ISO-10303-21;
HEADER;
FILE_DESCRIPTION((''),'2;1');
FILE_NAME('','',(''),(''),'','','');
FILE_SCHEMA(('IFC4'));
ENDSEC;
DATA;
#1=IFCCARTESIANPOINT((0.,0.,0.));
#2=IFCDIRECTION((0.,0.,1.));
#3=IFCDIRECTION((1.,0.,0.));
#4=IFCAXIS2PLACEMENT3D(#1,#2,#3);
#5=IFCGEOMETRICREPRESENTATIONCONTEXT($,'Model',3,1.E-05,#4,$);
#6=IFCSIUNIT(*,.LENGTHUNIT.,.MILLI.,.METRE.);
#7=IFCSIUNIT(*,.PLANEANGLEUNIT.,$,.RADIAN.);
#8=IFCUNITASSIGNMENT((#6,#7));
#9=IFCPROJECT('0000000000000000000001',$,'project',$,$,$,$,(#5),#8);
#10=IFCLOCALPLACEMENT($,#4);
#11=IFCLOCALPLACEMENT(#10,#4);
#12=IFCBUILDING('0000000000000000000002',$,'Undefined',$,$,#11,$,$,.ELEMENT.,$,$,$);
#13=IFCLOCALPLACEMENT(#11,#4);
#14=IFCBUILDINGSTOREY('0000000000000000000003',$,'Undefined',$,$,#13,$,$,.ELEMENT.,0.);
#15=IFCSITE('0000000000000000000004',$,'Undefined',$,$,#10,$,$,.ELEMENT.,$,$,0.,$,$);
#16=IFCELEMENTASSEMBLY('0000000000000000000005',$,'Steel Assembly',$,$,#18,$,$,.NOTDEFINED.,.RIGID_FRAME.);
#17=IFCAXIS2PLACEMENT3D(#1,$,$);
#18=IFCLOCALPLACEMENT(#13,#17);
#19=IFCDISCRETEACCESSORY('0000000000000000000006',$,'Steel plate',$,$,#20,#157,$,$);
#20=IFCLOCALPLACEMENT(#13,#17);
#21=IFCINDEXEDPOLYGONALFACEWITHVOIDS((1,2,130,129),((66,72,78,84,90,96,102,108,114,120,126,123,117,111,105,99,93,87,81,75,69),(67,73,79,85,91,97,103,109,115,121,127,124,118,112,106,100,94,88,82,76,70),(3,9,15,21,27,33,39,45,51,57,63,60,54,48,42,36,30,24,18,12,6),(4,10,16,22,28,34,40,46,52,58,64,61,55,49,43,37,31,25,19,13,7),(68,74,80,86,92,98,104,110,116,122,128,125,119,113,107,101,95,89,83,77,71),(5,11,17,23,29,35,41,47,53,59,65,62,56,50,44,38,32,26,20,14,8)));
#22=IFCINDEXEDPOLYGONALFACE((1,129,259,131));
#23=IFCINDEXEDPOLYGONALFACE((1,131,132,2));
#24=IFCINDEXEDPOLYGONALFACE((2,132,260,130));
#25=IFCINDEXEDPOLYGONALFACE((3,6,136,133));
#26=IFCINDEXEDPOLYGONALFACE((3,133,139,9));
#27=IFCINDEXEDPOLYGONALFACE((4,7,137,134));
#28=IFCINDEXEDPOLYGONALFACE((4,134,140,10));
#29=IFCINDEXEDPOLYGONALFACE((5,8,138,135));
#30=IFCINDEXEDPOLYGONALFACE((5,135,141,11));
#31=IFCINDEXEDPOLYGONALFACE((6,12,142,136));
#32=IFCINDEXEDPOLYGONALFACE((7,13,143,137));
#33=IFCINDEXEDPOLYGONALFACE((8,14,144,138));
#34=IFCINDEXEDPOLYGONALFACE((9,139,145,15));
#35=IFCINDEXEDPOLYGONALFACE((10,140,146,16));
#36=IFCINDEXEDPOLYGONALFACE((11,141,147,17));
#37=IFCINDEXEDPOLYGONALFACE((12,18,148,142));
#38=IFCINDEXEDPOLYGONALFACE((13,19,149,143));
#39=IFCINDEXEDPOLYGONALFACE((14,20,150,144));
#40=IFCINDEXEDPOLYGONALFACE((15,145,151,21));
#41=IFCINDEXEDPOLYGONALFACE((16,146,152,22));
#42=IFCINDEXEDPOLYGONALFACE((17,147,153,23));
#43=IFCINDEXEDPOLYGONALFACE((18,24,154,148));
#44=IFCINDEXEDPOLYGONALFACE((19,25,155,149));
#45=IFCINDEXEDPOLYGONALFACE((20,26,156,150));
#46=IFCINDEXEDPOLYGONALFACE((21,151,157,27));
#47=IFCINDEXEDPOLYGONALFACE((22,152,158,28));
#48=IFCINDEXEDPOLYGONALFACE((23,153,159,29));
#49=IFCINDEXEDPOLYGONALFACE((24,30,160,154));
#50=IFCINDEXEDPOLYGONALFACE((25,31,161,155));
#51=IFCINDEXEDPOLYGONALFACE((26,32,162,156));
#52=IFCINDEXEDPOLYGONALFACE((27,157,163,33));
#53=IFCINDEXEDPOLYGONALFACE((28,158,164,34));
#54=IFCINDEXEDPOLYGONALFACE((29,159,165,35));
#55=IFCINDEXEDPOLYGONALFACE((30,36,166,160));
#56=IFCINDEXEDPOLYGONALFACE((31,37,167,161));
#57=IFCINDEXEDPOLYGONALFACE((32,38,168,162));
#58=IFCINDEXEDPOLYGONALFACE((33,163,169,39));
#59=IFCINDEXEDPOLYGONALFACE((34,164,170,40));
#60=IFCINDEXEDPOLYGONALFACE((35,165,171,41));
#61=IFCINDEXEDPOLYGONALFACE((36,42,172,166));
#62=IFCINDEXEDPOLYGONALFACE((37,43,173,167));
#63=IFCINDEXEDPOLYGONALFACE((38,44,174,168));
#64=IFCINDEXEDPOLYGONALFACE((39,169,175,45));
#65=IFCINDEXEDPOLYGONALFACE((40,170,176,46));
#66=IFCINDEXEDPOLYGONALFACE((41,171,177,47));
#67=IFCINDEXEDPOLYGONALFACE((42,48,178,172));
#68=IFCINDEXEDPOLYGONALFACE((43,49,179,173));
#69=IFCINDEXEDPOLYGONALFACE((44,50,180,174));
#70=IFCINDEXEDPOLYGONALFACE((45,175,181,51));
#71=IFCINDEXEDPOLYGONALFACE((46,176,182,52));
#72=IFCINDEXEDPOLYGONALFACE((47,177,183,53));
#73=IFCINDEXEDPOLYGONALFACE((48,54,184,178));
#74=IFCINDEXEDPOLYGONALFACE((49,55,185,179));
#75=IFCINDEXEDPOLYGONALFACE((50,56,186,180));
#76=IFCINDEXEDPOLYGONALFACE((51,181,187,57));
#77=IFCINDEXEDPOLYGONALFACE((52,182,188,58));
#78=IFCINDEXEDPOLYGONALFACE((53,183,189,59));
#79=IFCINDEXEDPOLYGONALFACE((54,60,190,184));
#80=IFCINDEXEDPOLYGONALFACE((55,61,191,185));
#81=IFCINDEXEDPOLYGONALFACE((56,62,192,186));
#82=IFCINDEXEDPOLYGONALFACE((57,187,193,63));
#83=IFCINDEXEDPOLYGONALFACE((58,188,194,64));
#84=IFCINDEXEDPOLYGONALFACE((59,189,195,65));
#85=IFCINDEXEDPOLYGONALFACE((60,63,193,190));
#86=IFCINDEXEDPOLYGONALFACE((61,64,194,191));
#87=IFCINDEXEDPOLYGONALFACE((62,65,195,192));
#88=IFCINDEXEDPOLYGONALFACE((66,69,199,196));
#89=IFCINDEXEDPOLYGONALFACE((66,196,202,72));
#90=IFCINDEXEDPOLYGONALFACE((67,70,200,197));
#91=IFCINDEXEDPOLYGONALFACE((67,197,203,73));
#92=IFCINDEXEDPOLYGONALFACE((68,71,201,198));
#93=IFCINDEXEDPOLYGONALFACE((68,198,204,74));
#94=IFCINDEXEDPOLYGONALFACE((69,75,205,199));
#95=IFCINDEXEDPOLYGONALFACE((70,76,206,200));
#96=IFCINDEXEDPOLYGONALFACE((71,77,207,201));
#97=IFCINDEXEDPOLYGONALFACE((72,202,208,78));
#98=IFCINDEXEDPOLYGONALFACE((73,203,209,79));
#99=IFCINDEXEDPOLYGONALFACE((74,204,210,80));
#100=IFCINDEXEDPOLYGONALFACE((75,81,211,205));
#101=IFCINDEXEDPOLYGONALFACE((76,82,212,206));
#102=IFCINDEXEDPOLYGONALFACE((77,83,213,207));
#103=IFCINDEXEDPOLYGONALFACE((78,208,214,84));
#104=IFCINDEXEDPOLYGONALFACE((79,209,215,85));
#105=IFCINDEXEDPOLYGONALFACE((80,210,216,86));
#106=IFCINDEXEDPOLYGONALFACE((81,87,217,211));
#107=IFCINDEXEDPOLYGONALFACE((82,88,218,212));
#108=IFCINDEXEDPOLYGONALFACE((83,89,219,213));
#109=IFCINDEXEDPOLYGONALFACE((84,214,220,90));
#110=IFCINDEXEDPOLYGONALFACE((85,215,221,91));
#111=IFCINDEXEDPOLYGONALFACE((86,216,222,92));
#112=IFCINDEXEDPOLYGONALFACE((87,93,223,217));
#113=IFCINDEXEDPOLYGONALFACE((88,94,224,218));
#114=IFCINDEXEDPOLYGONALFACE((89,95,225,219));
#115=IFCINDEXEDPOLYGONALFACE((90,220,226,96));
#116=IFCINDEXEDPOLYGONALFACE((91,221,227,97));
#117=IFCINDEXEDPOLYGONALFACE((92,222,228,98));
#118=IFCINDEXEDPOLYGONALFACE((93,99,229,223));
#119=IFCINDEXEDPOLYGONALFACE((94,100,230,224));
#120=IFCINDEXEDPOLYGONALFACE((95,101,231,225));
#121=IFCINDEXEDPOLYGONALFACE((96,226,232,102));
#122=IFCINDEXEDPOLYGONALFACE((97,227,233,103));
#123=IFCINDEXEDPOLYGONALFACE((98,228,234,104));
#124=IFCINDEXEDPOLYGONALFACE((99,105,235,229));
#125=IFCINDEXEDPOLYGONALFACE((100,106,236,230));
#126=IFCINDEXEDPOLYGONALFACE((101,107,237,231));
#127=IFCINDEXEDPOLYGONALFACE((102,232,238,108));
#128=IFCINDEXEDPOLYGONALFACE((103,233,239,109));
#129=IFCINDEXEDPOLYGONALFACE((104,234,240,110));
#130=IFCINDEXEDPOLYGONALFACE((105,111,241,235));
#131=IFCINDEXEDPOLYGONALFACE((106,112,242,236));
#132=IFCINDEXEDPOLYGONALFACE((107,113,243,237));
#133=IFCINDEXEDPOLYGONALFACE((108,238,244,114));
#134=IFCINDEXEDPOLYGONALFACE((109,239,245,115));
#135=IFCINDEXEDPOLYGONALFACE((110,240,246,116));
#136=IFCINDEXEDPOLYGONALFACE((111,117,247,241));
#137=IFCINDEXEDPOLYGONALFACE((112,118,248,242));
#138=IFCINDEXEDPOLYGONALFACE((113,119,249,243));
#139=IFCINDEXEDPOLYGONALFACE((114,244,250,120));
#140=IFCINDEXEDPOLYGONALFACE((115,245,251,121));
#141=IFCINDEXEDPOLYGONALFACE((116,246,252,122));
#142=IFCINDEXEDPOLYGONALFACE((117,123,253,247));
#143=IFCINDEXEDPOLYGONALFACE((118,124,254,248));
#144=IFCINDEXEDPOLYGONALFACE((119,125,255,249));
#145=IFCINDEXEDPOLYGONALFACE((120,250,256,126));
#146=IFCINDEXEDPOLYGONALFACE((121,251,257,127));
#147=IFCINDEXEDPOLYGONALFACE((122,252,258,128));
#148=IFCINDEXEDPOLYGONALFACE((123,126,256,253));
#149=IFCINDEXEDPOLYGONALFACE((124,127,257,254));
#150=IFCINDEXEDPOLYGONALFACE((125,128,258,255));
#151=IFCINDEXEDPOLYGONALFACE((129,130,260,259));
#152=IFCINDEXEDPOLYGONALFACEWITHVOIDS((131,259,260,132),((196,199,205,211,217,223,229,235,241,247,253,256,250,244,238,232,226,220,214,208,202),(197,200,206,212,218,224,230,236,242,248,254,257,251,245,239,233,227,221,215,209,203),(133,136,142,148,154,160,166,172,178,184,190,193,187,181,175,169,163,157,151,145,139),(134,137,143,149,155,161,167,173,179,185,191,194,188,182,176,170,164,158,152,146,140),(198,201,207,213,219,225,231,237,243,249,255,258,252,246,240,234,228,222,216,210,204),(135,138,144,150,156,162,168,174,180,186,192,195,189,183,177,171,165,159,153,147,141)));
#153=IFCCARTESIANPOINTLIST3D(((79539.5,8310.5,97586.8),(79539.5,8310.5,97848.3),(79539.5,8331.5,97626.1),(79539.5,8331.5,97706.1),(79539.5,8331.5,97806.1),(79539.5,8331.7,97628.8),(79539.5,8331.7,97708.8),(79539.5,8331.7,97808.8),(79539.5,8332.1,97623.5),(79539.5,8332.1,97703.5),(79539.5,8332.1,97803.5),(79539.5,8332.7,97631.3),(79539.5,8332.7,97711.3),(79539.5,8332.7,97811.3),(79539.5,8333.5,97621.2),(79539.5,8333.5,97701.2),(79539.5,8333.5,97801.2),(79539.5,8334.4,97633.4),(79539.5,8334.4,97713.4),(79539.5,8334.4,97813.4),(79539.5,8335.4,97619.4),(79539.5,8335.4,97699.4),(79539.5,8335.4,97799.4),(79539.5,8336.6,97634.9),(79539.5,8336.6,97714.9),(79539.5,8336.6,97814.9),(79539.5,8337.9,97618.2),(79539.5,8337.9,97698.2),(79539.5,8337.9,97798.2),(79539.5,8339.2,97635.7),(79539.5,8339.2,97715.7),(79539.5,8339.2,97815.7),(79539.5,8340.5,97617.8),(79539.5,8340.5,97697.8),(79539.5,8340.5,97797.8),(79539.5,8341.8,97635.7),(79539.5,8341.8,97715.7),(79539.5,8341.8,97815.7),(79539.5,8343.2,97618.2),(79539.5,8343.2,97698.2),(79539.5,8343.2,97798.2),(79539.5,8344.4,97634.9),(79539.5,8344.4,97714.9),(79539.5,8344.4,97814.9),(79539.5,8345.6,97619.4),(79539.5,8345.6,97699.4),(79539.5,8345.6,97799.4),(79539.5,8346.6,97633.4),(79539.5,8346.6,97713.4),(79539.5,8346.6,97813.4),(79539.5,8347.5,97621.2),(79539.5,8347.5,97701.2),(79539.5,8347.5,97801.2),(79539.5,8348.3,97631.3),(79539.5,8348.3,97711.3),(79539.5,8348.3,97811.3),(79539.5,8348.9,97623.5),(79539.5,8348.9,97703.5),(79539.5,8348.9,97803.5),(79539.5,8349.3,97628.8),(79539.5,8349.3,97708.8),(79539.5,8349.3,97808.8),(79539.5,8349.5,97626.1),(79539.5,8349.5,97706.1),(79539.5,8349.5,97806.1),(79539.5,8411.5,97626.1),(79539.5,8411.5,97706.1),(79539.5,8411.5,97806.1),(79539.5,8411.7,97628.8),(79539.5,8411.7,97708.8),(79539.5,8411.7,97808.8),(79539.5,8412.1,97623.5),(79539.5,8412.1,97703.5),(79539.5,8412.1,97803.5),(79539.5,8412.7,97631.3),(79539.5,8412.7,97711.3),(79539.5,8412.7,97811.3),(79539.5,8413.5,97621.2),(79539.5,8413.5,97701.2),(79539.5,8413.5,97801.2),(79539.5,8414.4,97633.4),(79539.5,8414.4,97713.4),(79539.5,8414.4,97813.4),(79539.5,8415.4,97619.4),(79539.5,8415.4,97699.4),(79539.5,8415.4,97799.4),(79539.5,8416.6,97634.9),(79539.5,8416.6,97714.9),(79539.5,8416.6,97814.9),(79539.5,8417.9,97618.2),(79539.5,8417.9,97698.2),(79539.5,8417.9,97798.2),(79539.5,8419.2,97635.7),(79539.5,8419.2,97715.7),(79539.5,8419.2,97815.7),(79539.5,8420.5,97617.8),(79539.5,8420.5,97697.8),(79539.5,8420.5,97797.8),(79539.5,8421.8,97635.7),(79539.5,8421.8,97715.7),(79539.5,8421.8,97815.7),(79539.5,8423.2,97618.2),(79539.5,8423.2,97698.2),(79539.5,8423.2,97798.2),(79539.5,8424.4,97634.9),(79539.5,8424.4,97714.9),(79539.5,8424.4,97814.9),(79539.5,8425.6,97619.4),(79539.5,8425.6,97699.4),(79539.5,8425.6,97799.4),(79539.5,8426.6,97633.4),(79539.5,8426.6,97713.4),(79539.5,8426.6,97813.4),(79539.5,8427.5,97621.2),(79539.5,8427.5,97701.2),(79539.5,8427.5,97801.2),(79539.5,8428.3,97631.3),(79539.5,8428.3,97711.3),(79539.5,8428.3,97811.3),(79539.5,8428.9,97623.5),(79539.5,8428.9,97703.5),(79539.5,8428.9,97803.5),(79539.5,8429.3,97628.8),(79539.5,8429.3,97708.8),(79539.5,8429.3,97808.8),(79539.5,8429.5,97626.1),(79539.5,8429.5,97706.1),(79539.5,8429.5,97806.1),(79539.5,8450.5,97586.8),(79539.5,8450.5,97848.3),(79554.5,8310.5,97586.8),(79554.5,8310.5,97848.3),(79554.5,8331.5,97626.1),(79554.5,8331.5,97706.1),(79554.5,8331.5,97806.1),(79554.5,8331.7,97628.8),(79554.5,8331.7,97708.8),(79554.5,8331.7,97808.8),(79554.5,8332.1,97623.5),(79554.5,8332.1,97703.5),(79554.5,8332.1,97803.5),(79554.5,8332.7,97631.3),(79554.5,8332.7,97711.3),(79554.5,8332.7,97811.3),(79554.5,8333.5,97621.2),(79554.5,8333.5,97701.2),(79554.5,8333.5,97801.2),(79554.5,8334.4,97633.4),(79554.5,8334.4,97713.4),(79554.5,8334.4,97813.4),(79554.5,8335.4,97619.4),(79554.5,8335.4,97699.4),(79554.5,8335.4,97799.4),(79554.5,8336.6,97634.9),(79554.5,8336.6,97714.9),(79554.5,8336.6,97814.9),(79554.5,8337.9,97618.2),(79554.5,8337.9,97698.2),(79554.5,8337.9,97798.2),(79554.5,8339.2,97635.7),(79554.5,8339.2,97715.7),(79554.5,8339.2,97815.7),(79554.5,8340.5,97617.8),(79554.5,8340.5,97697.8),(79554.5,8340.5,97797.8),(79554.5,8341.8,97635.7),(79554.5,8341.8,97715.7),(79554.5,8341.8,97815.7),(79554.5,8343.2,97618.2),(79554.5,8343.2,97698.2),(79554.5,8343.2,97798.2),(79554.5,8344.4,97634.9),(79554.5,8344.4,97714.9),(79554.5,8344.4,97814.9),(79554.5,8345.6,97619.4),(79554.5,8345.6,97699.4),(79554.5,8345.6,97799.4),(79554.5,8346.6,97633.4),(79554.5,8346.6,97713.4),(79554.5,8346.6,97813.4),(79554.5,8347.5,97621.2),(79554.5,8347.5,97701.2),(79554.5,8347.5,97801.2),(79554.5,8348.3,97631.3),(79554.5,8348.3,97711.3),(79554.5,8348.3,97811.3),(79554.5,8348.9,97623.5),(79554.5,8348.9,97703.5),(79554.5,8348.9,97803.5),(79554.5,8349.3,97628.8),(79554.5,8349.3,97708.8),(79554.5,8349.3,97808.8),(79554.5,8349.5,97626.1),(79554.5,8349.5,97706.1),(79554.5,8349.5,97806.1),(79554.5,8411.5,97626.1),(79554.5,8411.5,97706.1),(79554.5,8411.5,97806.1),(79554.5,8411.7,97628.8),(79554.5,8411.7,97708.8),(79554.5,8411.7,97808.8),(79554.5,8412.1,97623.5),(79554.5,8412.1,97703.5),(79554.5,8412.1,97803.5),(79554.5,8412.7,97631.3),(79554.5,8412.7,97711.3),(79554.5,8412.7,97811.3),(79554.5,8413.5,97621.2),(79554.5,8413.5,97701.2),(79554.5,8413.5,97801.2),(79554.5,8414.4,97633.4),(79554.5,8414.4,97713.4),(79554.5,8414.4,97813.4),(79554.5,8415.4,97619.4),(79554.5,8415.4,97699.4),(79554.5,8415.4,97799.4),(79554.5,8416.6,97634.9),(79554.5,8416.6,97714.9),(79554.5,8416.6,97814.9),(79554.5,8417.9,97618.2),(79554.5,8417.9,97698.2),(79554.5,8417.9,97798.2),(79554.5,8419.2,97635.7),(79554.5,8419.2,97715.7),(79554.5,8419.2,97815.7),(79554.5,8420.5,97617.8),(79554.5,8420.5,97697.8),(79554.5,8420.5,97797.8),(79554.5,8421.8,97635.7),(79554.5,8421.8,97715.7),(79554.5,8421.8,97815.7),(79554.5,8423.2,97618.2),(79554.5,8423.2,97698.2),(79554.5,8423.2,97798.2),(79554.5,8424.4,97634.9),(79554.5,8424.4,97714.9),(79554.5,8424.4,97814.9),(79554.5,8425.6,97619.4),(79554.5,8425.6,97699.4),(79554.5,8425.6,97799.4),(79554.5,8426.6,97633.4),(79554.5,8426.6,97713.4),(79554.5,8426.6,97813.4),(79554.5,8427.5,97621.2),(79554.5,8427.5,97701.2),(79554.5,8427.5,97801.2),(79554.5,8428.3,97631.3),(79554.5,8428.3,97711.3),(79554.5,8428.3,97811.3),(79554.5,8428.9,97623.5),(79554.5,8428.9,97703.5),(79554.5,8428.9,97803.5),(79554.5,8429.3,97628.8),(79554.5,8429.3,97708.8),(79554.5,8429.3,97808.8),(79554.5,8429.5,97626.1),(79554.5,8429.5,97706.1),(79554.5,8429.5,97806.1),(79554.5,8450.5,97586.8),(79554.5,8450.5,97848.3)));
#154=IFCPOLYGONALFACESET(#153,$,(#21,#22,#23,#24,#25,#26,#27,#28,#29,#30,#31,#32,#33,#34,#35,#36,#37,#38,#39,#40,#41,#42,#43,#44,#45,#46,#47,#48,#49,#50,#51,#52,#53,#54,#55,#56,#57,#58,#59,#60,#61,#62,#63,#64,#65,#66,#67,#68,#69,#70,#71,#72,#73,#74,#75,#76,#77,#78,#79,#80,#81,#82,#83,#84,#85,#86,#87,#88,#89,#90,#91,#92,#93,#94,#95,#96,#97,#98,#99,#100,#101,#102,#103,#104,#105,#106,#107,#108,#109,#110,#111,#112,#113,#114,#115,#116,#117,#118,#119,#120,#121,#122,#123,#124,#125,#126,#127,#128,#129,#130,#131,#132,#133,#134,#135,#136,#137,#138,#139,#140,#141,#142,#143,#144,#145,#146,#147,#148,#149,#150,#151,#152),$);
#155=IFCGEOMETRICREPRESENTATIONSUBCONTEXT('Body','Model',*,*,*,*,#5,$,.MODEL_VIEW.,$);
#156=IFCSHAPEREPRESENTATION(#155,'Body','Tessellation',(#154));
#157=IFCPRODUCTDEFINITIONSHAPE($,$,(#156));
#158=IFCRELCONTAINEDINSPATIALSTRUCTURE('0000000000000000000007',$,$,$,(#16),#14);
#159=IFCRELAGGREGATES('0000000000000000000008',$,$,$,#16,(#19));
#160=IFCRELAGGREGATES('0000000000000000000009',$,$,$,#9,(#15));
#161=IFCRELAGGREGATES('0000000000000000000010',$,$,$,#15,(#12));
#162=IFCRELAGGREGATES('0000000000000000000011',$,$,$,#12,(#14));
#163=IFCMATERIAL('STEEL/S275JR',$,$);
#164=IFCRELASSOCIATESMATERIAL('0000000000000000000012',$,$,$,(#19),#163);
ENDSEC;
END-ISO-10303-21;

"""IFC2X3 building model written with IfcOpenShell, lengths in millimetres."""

from ifc_helpers import new_model, si_unit, frame, origin_with_axes, origin_2d_with_axis, place, context, subcontext, project, spatial, polyline, circle, outline, extrude, source, transform, mapped, material, element, aggregate, save


model = new_model("IFC2X3")

# Units and contexts
model_context = context("Model", 3, precision=1e-05, world=origin_with_axes())
body_context = subcontext(model_context, "Body", "Model", "MODEL_VIEW")
ifc_project = project(units=[si_unit("LENGTHUNIT", "METRE", prefix="MILLI"), si_unit("PLANEANGLEUNIT", "RADIAN")], contexts=[model_context])

# Site, building, storey
site_placement = place(None, origin_with_axes())
site = spatial("IfcSite", under=ifc_project, at=site_placement, Name="Undefined", CompositionType="ELEMENT", RefElevation=0.0)
building_placement = place(site_placement, origin_with_axes())
building = spatial("IfcBuilding", under=site, at=building_placement, Name="Undefined", CompositionType="ELEMENT")
storey_placement = place(building_placement, origin_with_axes())
storey = spatial("IfcBuildingStorey", under=building, at=storey_placement, Name="Undefined", CompositionType="ELEMENT", Elevation=0.0)

# Shared definitions
ifc_material_1 = material(Name="STEEL/S275JR")

# Element assembly
assembly_1_placement = place(storey_placement, origin_with_axes())
assembly_1 = element("IfcElementAssembly", 1, at=assembly_1_placement, inside=storey, Name="Steel Assembly", AssemblyPlace="NOTDEFINED", PredefinedType="RIGID_FRAME")

# Shared definitions
shared_shape_1 = source(origin_with_axes(), body_context, "Body", "SweptSolid", [
    extrude(circle(Radius=9.0, at=origin_2d_with_axis()), frame((0.0, -20.1, 0.0), z_axis=(0.0, 1.0, 0.0), x_axis=(1.0, 0.0, 0.0)), (0.0, 0.0, 1.0), 35.3),
])

# Discrete accessory, opening
discrete_accessory_1_placement = place(assembly_1_placement, frame((79547.0, 8310.5, 97848.3), z_axis=(-1.0, 0.0, 0.0), x_axis=(0.0, 1.0, 0.0)))
discrete_accessory_1 = element("IfcDiscreteAccessory", 2, at=discrete_accessory_1_placement, material=ifc_material_1, Name="Steel plate", context=body_context, shape_type="SweptSolid", body=[
    extrude(outline(polyline([(0.0, 0.0), (140.0, 0.0), (140.0, 261.5), (0.0, 261.5), (0.0, 0.0)])), frame((0.0, 0.0, -7.5), z_axis=(0.0, 0.0, 1.0), x_axis=(1.0, 0.0, 0.0)), (0.0, 0.0, 1.0), 15.0),
])
opening_1_placement = place(assembly_1_placement, frame((79559.5, 8380.5, 97806.8), z_axis=(0.0, -1.0, 0.0), x_axis=(0.0, 0.0, -1.0)))
element("IfcOpeningElement", 3, at=opening_1_placement, cuts=discrete_accessory_1, ObjectType="Opening", context=body_context, shape_type="MappedRepresentation", body=[
    mapped(shared_shape_1, transform((0.0, 0.0, -40.0))),
    mapped(shared_shape_1, transform((100.0, 0.0, -40.0))),
    mapped(shared_shape_1, transform((180.0, 0.0, -40.0))),
    mapped(shared_shape_1, transform((0.0, 0.0, 40.0))),
    mapped(shared_shape_1, transform((100.0, 0.0, 40.0))),
    mapped(shared_shape_1, transform((180.0, 0.0, 40.0))),
])
aggregate(assembly_1, [discrete_accessory_1])

save(model, "model.ifc")
